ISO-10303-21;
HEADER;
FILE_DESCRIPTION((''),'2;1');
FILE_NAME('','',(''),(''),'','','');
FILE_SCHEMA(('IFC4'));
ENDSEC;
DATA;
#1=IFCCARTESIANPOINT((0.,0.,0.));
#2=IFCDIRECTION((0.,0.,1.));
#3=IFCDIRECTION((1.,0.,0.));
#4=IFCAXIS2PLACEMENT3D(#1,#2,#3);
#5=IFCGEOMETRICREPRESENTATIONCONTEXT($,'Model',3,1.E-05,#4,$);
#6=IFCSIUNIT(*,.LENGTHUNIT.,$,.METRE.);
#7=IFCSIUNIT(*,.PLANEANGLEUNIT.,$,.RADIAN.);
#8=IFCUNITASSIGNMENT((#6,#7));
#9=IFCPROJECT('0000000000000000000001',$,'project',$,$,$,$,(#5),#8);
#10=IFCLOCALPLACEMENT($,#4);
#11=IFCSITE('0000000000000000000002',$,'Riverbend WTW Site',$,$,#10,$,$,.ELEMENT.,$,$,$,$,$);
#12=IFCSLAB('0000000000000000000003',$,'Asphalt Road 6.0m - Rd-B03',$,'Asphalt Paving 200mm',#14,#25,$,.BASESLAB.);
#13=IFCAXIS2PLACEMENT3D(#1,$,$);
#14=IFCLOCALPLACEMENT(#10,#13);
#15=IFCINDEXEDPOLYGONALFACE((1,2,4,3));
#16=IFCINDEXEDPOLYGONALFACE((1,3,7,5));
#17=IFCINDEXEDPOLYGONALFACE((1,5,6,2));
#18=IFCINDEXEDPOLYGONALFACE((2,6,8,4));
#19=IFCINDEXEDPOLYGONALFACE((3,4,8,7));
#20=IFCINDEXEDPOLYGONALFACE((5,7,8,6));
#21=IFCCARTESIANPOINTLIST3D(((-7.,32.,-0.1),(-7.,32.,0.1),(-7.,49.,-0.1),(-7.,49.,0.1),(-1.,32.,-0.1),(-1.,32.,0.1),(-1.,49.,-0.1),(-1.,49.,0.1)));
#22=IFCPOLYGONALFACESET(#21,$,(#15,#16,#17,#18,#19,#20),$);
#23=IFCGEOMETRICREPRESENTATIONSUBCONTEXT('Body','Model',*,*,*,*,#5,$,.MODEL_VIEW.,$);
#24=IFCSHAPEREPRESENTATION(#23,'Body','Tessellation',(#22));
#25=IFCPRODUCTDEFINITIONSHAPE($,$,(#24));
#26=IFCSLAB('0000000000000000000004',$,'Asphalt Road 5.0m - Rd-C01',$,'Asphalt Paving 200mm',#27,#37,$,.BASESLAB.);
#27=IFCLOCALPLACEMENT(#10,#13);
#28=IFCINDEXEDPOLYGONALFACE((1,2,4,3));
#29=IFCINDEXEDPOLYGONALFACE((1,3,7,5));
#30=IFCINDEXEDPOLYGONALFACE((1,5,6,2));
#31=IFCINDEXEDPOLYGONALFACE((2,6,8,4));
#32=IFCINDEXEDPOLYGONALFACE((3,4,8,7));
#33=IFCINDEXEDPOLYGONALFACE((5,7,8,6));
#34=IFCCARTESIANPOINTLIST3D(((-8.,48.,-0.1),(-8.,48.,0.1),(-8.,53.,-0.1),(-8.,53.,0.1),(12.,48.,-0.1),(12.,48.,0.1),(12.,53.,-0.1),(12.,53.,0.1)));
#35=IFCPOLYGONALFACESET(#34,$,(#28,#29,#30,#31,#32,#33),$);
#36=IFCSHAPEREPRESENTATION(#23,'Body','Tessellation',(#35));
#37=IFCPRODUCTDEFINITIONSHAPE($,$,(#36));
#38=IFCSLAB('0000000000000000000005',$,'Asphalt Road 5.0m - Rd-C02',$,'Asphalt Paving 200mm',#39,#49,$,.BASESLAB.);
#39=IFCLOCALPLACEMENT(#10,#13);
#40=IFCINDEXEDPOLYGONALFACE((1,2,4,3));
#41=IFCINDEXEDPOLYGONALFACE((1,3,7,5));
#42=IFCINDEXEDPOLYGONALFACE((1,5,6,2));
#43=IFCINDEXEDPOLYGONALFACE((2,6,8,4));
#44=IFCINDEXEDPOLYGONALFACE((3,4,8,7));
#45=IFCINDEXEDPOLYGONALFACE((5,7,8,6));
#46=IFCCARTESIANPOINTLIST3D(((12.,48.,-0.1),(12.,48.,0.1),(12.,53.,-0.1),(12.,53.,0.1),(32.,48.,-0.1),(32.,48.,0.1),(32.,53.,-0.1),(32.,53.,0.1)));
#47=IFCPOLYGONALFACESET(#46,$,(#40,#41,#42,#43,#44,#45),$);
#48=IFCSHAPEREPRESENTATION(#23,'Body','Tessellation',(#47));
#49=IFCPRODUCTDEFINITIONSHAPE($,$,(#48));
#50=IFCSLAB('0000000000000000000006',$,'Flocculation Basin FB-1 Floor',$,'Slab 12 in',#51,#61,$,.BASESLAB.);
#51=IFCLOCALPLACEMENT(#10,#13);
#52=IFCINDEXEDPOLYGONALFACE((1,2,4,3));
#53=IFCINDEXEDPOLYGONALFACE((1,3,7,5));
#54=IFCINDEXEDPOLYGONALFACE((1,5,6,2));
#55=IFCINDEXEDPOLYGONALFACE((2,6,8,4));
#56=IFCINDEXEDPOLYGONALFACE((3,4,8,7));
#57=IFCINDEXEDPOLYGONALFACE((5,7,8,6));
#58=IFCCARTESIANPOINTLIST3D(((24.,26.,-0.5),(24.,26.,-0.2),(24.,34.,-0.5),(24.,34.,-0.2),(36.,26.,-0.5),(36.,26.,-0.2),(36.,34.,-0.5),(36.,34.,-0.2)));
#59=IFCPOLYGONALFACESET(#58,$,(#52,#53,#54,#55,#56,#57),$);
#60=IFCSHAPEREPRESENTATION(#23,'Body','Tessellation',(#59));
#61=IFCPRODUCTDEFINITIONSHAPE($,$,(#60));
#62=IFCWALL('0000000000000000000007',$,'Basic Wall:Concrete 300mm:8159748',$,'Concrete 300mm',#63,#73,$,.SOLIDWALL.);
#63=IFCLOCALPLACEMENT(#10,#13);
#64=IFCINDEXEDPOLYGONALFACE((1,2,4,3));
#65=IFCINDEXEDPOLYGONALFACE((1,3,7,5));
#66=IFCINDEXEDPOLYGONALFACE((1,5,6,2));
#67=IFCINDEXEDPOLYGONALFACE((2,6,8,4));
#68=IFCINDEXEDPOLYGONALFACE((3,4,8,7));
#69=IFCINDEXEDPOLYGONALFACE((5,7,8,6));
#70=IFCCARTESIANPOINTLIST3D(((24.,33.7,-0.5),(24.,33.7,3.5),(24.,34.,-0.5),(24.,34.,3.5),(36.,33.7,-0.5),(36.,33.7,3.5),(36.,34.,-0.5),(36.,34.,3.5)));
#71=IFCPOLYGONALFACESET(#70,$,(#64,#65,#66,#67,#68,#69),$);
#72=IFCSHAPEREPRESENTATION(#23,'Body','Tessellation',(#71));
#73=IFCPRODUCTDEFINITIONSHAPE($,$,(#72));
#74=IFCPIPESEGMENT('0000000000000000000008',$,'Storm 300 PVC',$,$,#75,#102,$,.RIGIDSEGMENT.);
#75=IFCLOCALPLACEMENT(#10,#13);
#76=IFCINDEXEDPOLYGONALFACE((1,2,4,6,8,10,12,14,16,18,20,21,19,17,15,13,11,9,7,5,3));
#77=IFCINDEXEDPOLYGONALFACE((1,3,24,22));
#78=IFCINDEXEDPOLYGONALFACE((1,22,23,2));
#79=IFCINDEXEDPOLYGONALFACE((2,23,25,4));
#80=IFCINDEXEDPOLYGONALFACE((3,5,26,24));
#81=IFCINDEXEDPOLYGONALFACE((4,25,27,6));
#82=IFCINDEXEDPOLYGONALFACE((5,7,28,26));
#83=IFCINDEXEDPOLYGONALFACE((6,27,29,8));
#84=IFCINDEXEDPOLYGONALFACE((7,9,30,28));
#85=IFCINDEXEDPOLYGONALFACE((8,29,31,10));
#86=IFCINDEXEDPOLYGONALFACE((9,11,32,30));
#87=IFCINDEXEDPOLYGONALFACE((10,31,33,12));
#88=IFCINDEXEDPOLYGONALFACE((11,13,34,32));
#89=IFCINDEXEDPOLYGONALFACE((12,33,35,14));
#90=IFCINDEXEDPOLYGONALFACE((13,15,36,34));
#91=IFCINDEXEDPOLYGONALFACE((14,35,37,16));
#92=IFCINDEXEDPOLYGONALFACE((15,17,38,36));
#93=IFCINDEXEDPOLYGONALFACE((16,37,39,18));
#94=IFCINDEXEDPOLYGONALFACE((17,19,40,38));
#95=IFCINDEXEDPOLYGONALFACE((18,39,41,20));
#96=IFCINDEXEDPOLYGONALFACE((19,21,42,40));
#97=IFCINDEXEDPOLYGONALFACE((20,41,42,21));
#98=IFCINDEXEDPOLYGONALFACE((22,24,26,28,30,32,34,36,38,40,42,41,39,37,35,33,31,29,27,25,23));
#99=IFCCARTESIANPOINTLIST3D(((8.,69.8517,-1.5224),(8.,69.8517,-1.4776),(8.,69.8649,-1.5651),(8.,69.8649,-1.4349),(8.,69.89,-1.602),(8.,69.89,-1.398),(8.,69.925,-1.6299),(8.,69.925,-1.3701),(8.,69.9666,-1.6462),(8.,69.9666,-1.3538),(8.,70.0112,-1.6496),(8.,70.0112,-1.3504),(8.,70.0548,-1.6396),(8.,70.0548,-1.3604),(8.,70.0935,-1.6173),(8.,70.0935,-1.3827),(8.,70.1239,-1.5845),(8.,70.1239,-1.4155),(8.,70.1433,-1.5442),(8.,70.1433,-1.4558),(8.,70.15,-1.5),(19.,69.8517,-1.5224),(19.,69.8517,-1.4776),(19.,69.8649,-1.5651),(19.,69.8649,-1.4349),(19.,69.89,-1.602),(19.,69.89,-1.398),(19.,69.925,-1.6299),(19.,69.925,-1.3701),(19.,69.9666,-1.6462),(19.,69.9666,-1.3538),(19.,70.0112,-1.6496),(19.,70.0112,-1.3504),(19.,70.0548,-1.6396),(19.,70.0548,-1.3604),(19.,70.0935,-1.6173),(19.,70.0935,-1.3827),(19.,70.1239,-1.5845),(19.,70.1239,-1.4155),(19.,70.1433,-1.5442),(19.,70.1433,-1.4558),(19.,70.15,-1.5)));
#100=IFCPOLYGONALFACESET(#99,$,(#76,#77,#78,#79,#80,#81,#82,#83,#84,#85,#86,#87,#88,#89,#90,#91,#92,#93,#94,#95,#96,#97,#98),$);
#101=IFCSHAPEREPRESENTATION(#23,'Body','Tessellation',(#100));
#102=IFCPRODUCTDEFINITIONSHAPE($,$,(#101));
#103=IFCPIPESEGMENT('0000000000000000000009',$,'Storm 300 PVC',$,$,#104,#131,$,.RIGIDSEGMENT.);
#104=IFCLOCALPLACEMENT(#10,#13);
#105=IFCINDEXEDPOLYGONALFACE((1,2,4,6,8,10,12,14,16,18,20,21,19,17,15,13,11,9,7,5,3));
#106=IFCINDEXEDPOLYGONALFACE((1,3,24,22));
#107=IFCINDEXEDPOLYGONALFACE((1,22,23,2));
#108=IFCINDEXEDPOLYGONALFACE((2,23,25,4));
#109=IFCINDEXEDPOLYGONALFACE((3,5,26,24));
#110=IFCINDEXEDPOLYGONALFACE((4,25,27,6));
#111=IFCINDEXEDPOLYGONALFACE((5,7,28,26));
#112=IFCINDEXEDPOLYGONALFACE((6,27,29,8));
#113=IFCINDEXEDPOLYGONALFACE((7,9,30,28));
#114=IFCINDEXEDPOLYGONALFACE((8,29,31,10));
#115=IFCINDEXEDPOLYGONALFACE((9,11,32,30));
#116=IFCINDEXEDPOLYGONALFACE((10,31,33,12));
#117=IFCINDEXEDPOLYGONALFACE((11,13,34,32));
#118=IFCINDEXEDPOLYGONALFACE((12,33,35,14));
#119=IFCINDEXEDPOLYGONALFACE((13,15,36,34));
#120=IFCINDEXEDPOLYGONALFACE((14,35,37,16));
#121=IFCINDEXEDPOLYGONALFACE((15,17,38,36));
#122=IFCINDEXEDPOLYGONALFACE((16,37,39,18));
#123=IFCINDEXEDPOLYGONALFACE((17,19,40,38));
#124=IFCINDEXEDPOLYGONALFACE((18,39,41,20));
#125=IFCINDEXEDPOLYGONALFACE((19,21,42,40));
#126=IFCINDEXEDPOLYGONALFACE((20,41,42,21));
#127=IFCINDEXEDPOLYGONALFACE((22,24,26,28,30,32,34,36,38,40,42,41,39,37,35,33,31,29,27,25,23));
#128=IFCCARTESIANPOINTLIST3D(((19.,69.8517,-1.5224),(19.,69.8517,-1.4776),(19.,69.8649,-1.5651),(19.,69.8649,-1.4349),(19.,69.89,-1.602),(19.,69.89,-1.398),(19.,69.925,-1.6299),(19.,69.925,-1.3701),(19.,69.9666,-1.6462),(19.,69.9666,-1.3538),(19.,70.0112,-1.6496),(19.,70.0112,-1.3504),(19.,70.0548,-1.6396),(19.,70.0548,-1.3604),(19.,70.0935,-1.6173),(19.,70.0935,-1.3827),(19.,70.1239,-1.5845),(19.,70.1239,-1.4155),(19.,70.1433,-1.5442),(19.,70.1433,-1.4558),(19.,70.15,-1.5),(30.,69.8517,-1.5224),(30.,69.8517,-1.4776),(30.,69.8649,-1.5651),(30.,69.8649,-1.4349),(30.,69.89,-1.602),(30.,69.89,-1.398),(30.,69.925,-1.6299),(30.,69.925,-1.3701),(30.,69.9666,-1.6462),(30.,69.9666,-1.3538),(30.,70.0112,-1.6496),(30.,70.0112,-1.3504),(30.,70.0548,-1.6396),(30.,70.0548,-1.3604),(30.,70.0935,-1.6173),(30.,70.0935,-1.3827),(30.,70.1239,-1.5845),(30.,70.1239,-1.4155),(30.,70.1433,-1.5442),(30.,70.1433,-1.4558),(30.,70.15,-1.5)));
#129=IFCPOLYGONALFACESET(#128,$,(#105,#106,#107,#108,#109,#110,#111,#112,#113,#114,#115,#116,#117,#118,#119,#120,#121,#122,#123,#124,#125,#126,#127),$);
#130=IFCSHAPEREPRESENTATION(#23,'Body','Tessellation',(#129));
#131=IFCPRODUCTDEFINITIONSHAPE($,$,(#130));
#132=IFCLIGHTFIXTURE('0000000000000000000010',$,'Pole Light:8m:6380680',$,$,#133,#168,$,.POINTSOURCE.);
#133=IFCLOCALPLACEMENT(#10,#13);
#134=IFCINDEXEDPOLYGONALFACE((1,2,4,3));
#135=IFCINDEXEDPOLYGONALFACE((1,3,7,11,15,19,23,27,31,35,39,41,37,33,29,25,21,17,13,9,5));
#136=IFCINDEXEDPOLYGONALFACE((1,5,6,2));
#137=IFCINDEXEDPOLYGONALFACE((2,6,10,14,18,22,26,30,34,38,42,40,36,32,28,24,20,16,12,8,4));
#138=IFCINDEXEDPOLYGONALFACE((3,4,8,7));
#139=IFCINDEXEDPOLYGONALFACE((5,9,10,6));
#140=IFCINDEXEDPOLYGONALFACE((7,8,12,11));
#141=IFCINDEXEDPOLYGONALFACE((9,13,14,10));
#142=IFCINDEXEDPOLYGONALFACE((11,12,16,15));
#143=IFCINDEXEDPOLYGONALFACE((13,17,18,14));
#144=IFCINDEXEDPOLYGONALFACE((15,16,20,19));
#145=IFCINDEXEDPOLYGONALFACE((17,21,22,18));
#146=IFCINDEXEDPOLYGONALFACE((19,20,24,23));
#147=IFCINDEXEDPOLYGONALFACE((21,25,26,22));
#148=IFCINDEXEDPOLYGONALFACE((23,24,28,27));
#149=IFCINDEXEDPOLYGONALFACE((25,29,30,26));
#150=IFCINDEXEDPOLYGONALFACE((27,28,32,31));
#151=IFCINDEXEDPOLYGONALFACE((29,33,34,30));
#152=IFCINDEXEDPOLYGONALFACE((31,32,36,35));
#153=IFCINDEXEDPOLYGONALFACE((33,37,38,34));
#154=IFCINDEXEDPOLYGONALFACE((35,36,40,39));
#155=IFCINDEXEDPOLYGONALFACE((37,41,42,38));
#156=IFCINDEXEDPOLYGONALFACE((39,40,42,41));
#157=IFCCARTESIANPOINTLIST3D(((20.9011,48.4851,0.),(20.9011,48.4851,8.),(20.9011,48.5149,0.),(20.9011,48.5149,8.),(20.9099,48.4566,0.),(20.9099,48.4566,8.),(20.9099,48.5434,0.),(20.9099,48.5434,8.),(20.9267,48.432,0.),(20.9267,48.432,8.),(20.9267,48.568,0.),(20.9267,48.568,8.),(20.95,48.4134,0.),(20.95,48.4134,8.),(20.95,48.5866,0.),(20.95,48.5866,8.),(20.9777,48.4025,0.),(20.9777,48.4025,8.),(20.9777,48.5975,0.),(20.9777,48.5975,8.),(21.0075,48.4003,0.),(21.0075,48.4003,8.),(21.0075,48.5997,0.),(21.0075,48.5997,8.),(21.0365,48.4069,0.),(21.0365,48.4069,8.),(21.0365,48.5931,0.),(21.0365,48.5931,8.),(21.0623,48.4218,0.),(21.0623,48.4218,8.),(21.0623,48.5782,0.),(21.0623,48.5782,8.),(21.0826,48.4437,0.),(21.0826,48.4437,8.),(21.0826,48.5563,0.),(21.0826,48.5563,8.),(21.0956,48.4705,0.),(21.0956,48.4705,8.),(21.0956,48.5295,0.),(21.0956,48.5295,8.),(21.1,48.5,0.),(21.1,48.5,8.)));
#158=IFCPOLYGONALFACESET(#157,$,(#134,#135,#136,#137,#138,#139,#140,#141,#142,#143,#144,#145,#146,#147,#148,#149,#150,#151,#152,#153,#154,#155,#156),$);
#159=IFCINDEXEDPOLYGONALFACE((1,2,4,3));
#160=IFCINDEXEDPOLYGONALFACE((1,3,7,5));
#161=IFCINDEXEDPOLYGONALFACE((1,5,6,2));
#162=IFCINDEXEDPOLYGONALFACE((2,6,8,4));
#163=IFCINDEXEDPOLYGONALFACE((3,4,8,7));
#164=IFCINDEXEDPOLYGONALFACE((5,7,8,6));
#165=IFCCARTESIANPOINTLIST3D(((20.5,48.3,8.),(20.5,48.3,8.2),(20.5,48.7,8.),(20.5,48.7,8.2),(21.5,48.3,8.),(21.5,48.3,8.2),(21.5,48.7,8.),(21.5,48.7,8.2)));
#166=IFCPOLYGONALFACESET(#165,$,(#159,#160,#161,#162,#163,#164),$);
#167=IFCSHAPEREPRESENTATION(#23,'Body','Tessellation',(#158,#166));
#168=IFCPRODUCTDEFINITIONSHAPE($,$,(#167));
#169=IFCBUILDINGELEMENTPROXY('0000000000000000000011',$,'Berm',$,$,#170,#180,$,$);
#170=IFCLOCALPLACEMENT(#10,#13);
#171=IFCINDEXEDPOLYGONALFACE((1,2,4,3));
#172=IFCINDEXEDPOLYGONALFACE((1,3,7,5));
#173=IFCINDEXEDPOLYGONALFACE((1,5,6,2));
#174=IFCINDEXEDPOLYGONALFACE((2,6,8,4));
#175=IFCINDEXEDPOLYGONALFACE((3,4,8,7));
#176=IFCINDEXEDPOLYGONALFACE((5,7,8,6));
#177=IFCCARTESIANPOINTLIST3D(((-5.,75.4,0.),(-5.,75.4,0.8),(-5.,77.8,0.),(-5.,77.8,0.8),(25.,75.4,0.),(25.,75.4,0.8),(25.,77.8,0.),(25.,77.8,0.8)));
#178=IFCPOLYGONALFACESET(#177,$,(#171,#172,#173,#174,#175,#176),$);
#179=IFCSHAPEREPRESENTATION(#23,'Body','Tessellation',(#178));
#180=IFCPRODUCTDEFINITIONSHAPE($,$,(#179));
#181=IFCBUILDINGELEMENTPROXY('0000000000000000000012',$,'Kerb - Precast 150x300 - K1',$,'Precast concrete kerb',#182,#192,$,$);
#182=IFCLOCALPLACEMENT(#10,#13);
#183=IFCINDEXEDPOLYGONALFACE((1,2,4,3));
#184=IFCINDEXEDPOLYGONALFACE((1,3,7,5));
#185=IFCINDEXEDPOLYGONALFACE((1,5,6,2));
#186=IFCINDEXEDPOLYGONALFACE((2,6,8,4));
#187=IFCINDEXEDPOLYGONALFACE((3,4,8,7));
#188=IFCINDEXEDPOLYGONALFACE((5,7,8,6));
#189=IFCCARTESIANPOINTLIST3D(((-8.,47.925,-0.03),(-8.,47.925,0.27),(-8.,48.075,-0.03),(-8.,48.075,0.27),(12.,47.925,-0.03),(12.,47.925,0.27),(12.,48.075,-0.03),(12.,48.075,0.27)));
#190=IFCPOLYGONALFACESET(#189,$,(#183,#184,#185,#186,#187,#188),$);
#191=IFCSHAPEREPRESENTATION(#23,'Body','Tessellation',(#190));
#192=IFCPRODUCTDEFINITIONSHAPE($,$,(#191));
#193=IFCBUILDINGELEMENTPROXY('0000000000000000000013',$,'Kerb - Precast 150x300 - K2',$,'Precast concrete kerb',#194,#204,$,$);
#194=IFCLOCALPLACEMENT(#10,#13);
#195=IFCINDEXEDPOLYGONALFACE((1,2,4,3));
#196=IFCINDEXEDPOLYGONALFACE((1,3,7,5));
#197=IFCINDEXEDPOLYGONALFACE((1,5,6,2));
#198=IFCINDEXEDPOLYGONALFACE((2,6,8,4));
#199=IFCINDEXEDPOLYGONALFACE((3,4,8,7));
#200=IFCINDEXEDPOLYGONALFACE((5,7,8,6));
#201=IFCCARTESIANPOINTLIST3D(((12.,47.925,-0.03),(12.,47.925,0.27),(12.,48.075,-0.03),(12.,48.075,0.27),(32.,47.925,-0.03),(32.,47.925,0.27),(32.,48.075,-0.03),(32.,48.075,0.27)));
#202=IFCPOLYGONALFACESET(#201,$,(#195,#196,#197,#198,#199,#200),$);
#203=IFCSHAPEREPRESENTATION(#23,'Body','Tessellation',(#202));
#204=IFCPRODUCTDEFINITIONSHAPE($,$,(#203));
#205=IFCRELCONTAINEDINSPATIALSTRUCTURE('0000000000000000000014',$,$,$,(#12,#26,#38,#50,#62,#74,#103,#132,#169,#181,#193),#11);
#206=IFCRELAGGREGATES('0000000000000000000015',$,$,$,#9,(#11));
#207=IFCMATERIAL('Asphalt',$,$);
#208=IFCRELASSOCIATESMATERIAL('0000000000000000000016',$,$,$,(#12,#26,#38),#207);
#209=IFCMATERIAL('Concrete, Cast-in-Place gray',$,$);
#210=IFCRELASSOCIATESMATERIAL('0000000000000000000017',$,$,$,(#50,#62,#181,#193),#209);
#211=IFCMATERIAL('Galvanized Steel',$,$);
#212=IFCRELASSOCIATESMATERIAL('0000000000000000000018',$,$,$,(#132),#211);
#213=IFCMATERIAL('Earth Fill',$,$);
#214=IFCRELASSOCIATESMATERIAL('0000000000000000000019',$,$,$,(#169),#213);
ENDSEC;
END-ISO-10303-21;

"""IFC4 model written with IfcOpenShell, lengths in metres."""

from ifc_helpers import new_model, si_unit, frame, origin_with_axes, origin_2d, place, context, subcontext, project, spatial, rectangle, circle, extrude, material, element, save


model = new_model("IFC4")

# Units and contexts
model_context = context("Model", 3, precision=1e-05, world=origin_with_axes())
body_context = subcontext(model_context, "Body", "Model", "MODEL_VIEW")
ifc_project = project(units=[si_unit("LENGTHUNIT", "METRE"), si_unit("PLANEANGLEUNIT", "RADIAN")], contexts=[model_context])

# Site
site_placement = place(None, origin_with_axes())
site = spatial("IfcSite", under=ifc_project, at=site_placement, Name="Riverbend WTW Site", CompositionType="ELEMENT")

# Slabs
ifc_material_1 = material(Name="Asphalt")
slab_1_placement = place(None, frame((-4.0, 40.5, 0.0), z_axis=(0.0, 0.0, 1.0), x_axis=(1.0, 0.0, 0.0)))
element("IfcSlab", 1, at=slab_1_placement, inside=site, material=ifc_material_1, Name="Asphalt Road 6.0m - Rd-B03", ObjectType="Asphalt Paving 200mm", PredefinedType="BASESLAB", context=body_context, shape_type="SweptSolid", body=[
    extrude(rectangle(XDim=6.0, YDim=17.0, at=origin_2d()), frame((0.0, 0.0, -0.1), z_axis=(0.0, 0.0, 1.0), x_axis=(1.0, 0.0, 0.0)), (0.0, 0.0, 1.0), 0.2),
])
for number, where, z_axis, x_axis, name in (
    (2, (2.0, 50.5, 0.0), (0.0, 0.0, 1.0), (1.0, 0.0, 0.0), "Asphalt Road 5.0m - Rd-C01"),
    (3, (22.0, 50.5, 0.0), (0.0, 0.0, 1.0), (1.0, 0.0, 0.0), "Asphalt Road 5.0m - Rd-C02"),
):
    element("IfcSlab", number, at=place(None, frame(where, z_axis=z_axis, x_axis=x_axis)), inside=site, material=ifc_material_1, Name=name, ObjectType="Asphalt Paving 200mm", PredefinedType="BASESLAB", context=body_context, shape_type="SweptSolid", body=[
        extrude(rectangle(XDim=20.0, YDim=5.0, at=origin_2d()), frame((0.0, 0.0, -0.1), z_axis=(0.0, 0.0, 1.0), x_axis=(1.0, 0.0, 0.0)), (0.0, 0.0, 1.0), 0.2),
    ])
ifc_material_2 = material(Name="Concrete, Cast-in-Place gray")
slab_2_placement = place(None, frame((30.0, 30.0, -0.35), z_axis=(0.0, 0.0, 1.0), x_axis=(1.0, 0.0, 0.0)))
element("IfcSlab", 4, at=slab_2_placement, inside=site, material=ifc_material_2, Name="Flocculation Basin FB-1 Floor", ObjectType="Slab 12 in", PredefinedType="BASESLAB", context=body_context, shape_type="SweptSolid", body=[
    extrude(rectangle(XDim=12.0, YDim=8.0, at=origin_2d()), frame((0.0, 0.0, -0.15), z_axis=(0.0, 0.0, 1.0), x_axis=(1.0, 0.0, 0.0)), (0.0, 0.0, 1.0), 0.3),
])

# Wall
wall_placement = place(None, frame((30.0, 33.85, 1.5), z_axis=(0.0, 0.0, 1.0), x_axis=(1.0, 0.0, 0.0)))
element("IfcWall", 5, at=wall_placement, inside=site, material=ifc_material_2, Name="Basic Wall:Concrete 300mm:8159748", ObjectType="Concrete 300mm", PredefinedType="SOLIDWALL", context=body_context, shape_type="SweptSolid", body=[
    extrude(rectangle(XDim=12.0, YDim=0.3, at=origin_2d()), frame((0.0, 0.0, -2.0), z_axis=(0.0, 0.0, 1.0), x_axis=(1.0, 0.0, 0.0)), (0.0, 0.0, 1.0), 4.0),
])

# Pipe segments
for number, where, z_axis, x_axis, name in (
    (6, (8.0, 70.0, -1.5), (0.0, 0.0, 1.0), (1.0, 0.0, 0.0), "Storm 300 PVC"),
    (7, (19.0, 70.0, -1.5), (0.0, 0.0, 1.0), (1.0, 0.0, 0.0), "Storm 300 PVC"),
):
    element("IfcPipeSegment", number, at=place(None, frame(where, z_axis=z_axis, x_axis=x_axis)), inside=site, Name=name, PredefinedType="RIGIDSEGMENT", context=body_context, shape_type="SweptSolid", body=[
        extrude(circle(Radius=0.15, at=origin_2d()), frame((0.0, 0.0, 0.0), z_axis=(1.0, 0.0, 0.0), x_axis=(0.0, 1.0, 0.0)), (0.0, 0.0, 1.0), 11.0),
    ])

# Light fixture
ifc_material_3 = material(Name="Galvanized Steel")
light_fixture_placement = place(None, frame((21.0, 48.5, 0.0), z_axis=(0.0, 0.0, 1.0), x_axis=(1.0, 0.0, 0.0)))
element("IfcLightFixture", 8, at=light_fixture_placement, inside=site, material=ifc_material_3, Name="Pole Light:8m:6380680", PredefinedType="POINTSOURCE", context=body_context, shape_type="SweptSolid", body=[
    extrude(circle(Radius=0.1, at=origin_2d()), origin_with_axes(), (0.0, 0.0, 1.0), 8.0),
    extrude(rectangle(XDim=1.0, YDim=0.4, at=origin_2d()), frame((0.0, 0.0, 8.0), z_axis=(0.0, 0.0, 1.0), x_axis=(1.0, 0.0, 0.0)), (0.0, 0.0, 1.0), 0.2),
])

# Building element proxies
ifc_material_4 = material(Name="Earth Fill")
proxy_1_placement = place(None, frame((10.0, 76.6, 0.4), z_axis=(0.0, 0.0, 1.0), x_axis=(1.0, 0.0, 0.0)))
element("IfcBuildingElementProxy", 9, at=proxy_1_placement, inside=site, material=ifc_material_4, Name="Berm", context=body_context, shape_type="SweptSolid", body=[
    extrude(rectangle(XDim=30.0, YDim=2.4, at=origin_2d()), frame((0.0, 0.0, -0.4), z_axis=(0.0, 0.0, 1.0), x_axis=(1.0, 0.0, 0.0)), (0.0, 0.0, 1.0), 0.8),
])
for number, where, z_axis, x_axis, name in (
    (10, (2.0, 48.0, 0.12), (0.0, 0.0, 1.0), (1.0, 0.0, 0.0), "Kerb - Precast 150x300 - K1"),
    (11, (22.0, 48.0, 0.12), (0.0, 0.0, 1.0), (1.0, 0.0, 0.0), "Kerb - Precast 150x300 - K2"),
):
    element("IfcBuildingElementProxy", number, at=place(None, frame(where, z_axis=z_axis, x_axis=x_axis)), inside=site, material=ifc_material_2, Name=name, ObjectType="Precast concrete kerb", context=body_context, shape_type="SweptSolid", body=[
        extrude(rectangle(XDim=20.0, YDim=0.15, at=origin_2d()), frame((0.0, 0.0, -0.15), z_axis=(0.0, 0.0, 1.0), x_axis=(1.0, 0.0, 0.0)), (0.0, 0.0, 1.0), 0.3),
    ])

save(model, "model.ifc")
